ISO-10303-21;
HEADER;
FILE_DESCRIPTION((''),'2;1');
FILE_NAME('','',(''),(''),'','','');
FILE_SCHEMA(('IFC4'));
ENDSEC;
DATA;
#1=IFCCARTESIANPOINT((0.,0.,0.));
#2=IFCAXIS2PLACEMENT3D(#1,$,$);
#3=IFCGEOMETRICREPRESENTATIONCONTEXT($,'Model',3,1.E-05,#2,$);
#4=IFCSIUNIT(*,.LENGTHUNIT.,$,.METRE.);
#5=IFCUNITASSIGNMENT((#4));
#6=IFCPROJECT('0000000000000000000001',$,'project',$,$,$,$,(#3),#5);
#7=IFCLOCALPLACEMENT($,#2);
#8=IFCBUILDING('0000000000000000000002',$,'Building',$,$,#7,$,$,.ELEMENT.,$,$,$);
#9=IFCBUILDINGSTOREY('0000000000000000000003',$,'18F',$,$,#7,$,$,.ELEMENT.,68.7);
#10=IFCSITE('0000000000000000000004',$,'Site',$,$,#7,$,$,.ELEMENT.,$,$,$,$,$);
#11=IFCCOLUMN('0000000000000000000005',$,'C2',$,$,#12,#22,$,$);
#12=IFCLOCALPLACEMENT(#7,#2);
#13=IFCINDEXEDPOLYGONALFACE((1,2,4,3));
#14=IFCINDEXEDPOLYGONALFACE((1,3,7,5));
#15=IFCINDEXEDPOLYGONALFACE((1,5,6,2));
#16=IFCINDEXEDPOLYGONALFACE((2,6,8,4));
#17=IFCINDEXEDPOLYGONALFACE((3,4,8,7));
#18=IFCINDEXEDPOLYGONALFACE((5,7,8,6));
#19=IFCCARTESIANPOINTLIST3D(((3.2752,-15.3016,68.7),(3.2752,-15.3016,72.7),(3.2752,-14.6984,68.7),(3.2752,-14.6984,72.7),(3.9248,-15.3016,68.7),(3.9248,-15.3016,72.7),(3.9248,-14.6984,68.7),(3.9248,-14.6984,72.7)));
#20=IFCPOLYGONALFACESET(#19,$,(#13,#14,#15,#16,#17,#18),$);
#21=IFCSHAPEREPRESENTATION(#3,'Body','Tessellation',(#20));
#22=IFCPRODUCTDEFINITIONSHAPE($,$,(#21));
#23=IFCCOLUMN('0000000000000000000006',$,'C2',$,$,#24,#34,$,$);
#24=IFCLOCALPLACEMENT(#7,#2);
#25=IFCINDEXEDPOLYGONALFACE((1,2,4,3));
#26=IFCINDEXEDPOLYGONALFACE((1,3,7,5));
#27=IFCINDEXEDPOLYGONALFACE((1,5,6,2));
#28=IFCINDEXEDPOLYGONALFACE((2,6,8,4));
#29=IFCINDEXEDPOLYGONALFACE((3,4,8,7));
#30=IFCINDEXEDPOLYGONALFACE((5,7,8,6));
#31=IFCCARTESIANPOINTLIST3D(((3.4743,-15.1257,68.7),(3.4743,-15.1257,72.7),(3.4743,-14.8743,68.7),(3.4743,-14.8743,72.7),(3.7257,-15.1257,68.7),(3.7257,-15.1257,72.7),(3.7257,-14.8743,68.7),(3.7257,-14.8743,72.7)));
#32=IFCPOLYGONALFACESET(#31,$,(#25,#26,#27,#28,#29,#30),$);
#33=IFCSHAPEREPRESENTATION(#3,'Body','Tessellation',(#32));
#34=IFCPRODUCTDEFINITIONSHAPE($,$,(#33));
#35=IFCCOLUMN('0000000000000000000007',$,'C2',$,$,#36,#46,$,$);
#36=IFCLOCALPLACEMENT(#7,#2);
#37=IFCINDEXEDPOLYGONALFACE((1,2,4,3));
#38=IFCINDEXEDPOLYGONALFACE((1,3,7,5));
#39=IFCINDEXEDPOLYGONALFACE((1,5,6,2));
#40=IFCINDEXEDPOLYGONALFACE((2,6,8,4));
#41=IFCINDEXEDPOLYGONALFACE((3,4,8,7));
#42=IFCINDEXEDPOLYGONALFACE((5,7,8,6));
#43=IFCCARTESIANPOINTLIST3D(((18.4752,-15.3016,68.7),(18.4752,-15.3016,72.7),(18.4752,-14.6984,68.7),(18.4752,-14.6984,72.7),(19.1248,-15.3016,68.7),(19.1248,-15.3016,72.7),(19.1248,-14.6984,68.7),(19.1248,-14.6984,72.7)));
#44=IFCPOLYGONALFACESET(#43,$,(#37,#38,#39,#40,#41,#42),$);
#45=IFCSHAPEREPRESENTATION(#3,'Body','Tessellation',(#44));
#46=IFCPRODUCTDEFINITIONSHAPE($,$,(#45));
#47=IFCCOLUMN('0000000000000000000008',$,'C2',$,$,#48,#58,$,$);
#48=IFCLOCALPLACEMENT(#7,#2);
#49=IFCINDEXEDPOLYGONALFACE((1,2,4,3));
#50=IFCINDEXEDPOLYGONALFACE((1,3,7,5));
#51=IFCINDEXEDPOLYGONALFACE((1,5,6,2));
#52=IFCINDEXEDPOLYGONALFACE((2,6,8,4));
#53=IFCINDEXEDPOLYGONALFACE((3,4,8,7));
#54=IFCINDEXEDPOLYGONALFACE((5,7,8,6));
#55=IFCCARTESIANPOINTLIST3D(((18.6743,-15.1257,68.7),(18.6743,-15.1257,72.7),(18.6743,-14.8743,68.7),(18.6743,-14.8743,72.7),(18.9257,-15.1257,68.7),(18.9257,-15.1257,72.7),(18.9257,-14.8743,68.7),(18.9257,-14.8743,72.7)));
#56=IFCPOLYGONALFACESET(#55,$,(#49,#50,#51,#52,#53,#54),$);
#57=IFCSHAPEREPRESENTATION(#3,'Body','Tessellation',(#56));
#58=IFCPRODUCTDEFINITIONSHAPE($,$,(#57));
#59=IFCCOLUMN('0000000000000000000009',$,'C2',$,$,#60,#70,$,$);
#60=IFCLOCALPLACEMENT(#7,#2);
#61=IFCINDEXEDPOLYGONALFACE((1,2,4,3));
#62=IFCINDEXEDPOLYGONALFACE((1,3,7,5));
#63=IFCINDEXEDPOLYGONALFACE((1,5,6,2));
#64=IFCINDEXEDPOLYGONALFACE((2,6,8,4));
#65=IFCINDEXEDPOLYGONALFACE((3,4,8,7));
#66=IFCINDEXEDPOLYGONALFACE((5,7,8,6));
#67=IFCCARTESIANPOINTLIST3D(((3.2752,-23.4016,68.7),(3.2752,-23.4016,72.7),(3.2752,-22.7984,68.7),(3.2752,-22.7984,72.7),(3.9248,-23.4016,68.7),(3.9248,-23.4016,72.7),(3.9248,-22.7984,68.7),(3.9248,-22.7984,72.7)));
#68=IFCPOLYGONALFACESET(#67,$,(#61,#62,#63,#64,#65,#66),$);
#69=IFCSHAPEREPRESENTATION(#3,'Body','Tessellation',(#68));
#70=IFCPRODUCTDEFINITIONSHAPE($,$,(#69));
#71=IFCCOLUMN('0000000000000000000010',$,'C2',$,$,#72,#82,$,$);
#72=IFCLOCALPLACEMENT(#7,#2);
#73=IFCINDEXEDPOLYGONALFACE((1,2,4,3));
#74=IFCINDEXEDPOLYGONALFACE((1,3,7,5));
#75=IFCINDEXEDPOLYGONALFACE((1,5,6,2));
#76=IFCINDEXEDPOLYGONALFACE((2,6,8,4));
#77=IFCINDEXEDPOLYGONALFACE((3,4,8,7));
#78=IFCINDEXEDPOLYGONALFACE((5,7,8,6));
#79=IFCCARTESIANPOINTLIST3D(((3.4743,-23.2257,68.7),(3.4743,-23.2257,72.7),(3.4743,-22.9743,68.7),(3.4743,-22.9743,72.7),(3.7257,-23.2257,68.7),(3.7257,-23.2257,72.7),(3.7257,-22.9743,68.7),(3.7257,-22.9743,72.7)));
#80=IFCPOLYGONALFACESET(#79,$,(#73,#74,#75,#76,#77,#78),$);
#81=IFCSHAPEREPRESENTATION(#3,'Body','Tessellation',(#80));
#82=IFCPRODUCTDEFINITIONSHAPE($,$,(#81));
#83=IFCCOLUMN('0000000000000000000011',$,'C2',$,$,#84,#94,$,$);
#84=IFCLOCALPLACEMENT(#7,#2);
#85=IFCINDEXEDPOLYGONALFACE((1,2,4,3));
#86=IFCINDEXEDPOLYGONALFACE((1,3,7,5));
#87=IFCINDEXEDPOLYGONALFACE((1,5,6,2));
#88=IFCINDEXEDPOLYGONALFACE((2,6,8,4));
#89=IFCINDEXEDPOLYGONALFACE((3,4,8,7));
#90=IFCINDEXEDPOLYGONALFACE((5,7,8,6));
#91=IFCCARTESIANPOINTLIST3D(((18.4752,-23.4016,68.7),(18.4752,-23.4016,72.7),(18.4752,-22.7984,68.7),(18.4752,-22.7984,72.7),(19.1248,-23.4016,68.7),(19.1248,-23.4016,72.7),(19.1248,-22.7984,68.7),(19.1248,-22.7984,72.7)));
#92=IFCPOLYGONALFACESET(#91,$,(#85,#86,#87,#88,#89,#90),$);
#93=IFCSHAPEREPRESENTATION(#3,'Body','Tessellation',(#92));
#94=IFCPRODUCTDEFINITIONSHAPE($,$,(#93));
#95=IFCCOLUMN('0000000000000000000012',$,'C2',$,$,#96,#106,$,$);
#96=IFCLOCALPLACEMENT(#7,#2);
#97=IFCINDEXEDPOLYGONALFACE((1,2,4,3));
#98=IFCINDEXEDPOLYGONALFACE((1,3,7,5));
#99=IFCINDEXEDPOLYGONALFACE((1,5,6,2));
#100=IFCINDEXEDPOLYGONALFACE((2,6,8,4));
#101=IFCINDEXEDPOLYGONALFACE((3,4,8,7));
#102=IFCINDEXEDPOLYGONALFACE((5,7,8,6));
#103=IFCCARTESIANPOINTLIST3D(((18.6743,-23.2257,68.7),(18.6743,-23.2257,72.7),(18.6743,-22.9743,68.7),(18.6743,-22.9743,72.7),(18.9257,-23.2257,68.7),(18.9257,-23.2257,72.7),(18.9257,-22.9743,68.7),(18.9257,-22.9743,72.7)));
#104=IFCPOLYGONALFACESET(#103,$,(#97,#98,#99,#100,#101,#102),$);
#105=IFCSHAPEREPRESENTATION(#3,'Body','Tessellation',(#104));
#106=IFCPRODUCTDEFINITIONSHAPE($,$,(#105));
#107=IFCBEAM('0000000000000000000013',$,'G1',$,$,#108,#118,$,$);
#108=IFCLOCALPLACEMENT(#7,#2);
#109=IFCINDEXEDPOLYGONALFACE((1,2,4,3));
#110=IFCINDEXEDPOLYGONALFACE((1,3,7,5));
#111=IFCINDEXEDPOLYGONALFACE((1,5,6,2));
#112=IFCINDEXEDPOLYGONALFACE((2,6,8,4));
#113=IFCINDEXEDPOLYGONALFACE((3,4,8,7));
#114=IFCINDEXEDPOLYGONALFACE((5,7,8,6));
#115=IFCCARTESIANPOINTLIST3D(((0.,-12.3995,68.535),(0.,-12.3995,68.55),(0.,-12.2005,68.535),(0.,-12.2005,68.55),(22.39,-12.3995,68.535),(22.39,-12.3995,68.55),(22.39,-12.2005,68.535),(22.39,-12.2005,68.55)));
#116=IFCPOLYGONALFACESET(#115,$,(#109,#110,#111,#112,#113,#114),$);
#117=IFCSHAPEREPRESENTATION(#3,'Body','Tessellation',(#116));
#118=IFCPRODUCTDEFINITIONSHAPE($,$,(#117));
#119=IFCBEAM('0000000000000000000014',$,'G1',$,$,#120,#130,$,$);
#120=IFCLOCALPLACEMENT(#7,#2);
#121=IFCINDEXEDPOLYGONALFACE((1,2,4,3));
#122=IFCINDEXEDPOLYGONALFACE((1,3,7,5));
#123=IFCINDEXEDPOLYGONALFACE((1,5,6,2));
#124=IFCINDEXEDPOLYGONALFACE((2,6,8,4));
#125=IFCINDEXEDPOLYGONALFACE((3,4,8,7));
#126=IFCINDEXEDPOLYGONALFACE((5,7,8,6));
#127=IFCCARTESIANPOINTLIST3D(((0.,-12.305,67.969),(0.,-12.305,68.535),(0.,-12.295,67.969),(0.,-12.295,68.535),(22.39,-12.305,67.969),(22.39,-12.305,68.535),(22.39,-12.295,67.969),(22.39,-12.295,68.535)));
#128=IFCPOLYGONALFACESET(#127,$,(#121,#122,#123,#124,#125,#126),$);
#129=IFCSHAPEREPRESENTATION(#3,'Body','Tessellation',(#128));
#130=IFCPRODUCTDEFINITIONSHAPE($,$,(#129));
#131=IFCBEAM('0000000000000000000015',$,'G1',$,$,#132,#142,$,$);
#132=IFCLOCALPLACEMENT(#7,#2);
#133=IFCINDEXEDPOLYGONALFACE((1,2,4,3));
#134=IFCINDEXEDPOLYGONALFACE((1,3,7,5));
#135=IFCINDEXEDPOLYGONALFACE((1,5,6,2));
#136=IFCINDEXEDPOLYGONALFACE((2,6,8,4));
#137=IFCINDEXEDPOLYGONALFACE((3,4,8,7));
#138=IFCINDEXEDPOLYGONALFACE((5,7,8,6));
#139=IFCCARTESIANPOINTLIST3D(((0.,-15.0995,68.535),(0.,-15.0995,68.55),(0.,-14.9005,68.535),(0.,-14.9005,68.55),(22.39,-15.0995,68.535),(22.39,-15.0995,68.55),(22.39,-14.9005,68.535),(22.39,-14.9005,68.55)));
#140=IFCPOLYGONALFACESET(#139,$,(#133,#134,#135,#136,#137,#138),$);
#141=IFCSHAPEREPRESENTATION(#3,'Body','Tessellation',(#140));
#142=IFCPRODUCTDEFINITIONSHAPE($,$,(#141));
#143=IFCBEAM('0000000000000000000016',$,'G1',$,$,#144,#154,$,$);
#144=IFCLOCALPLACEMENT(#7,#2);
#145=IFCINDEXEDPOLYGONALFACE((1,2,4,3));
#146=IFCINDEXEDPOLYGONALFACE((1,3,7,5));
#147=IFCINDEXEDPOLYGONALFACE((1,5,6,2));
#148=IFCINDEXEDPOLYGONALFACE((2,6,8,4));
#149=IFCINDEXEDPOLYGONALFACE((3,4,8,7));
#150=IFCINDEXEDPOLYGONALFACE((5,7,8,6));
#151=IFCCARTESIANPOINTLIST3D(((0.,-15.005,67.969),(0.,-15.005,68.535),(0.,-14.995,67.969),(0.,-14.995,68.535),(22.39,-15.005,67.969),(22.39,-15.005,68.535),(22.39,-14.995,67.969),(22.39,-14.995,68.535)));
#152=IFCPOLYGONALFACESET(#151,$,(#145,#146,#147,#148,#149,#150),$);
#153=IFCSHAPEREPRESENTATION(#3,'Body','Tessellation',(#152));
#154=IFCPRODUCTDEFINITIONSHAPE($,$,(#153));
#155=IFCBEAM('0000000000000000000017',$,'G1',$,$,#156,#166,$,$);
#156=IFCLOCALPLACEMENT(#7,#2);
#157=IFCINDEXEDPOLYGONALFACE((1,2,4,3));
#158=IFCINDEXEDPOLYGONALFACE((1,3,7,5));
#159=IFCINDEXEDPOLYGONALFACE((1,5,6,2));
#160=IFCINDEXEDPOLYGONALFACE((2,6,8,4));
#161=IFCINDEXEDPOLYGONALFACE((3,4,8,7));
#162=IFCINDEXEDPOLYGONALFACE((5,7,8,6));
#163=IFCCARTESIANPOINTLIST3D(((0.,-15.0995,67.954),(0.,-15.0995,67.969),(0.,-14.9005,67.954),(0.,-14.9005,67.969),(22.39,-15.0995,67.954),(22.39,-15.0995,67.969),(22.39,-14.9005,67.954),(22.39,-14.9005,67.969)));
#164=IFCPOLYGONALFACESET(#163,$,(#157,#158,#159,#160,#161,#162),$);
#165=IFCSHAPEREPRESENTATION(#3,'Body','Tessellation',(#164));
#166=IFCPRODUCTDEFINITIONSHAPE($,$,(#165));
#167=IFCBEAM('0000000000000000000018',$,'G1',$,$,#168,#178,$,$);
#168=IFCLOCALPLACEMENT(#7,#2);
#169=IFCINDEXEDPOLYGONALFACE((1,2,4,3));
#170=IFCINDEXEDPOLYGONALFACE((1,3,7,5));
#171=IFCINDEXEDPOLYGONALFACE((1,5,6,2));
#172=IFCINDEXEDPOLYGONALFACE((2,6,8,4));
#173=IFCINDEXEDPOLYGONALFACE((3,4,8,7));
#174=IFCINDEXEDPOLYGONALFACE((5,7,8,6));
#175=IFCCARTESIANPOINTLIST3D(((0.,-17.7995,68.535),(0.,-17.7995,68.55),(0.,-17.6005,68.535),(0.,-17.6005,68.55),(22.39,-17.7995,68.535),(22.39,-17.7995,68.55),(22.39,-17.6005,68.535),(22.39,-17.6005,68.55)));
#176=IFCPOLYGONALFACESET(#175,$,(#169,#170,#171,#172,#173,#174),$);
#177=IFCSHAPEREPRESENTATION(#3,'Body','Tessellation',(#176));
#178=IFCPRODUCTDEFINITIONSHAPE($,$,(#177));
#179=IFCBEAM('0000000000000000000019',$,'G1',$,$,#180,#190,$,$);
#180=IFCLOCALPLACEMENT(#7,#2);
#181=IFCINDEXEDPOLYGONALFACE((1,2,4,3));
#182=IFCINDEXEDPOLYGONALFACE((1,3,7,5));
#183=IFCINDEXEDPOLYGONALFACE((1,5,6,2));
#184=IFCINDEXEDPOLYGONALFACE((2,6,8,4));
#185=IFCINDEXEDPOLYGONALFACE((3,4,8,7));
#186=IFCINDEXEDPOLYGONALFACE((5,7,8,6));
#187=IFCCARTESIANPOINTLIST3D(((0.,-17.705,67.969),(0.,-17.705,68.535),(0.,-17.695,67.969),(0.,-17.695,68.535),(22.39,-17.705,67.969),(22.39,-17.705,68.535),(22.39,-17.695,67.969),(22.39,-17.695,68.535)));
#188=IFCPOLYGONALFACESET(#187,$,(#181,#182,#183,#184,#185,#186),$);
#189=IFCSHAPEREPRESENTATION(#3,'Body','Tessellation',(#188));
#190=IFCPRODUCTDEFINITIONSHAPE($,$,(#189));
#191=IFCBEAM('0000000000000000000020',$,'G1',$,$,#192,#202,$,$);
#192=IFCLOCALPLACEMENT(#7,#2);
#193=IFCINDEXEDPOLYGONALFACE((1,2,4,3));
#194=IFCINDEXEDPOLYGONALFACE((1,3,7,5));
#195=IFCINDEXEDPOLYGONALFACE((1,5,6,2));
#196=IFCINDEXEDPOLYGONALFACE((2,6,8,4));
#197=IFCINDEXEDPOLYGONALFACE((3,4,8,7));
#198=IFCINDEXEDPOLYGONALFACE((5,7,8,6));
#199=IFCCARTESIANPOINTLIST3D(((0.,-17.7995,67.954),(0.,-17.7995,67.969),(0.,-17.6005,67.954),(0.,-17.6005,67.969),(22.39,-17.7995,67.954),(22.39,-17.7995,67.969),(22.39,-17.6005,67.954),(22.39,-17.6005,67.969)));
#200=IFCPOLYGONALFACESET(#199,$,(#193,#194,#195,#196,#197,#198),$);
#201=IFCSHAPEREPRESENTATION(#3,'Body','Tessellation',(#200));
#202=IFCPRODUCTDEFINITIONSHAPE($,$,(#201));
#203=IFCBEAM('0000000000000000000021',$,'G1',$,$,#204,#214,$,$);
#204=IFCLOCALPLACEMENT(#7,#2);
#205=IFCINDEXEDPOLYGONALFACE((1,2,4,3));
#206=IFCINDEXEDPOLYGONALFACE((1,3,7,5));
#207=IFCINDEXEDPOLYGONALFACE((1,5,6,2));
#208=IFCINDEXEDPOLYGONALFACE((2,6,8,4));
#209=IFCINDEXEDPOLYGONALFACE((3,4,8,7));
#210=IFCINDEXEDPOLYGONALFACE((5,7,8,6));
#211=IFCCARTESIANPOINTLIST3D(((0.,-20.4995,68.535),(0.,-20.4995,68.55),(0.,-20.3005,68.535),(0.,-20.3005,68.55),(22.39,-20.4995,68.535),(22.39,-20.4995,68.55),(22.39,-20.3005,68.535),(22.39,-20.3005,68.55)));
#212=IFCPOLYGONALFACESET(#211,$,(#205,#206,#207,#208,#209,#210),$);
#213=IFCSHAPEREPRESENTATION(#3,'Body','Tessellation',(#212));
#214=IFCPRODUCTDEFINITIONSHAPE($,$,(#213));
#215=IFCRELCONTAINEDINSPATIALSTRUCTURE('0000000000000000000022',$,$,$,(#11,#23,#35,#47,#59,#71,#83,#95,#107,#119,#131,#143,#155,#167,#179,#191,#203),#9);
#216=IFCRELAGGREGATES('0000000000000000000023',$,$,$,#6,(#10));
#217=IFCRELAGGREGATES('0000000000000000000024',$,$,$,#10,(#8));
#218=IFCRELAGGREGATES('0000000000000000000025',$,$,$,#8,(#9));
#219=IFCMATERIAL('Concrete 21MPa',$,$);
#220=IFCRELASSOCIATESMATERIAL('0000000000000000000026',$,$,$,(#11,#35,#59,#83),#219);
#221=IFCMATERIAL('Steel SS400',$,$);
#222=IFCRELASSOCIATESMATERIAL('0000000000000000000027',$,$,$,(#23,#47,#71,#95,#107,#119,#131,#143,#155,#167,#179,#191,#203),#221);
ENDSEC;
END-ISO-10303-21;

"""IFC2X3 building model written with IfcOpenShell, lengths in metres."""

from ifc_helpers import new_model, si_unit, frame, origin, origin_2d, place, context, project, spatial, rectangle, extrude, material, element, save


model = new_model("IFC2X3")

# Units and contexts
model_context = context("Model", 3, precision=1e-05, world=origin())
ifc_project = project(units=[si_unit("LENGTHUNIT", "METRE")], contexts=[model_context])

# Site, building, storey
placement = place(None, origin())
site = spatial("IfcSite", under=ifc_project, at=placement, Name="Site", CompositionType="ELEMENT")
building = spatial("IfcBuilding", under=site, at=placement, Name="Building", CompositionType="ELEMENT")
storey = spatial("IfcBuildingStorey", under=building, at=placement, Name="18F", CompositionType="ELEMENT", Elevation=68.7)

# Columns
ifc_material_1 = material(Name="Concrete 21MPa")
column_1_placement = place(None, frame((3.6, -15.0, 68.7)))
element("IfcColumn", 1, at=column_1_placement, inside=storey, material=ifc_material_1, Name="C2", context=model_context, shape_type="SweptSolid", body=[
    extrude(rectangle(XDim=0.6496, YDim=0.6032, at=origin_2d()), origin(), (0.0, 0.0, 1.0), 4.0),
])
ifc_material_2 = material(Name="Steel SS400")
column_2_placement = place(None, frame((3.6, -15.0, 68.7)))
element("IfcColumn", 2, at=column_2_placement, inside=storey, material=ifc_material_2, Name="C2", context=model_context, shape_type="SweptSolid", body=[
    extrude(rectangle(XDim=0.2513, YDim=0.2513, at=origin_2d()), origin(), (0.0, 0.0, 1.0), 4.0),
])
column_3_placement = place(None, frame((18.8, -15.0, 68.7)))
element("IfcColumn", 3, at=column_3_placement, inside=storey, material=ifc_material_1, Name="C2", context=model_context, shape_type="SweptSolid", body=[
    extrude(rectangle(XDim=0.6496, YDim=0.6032, at=origin_2d()), origin(), (0.0, 0.0, 1.0), 4.0),
])
column_4_placement = place(None, frame((18.8, -15.0, 68.7)))
element("IfcColumn", 4, at=column_4_placement, inside=storey, material=ifc_material_2, Name="C2", context=model_context, shape_type="SweptSolid", body=[
    extrude(rectangle(XDim=0.2513, YDim=0.2513, at=origin_2d()), origin(), (0.0, 0.0, 1.0), 4.0),
])
column_5_placement = place(None, frame((3.6, -23.1, 68.7)))
element("IfcColumn", 5, at=column_5_placement, inside=storey, material=ifc_material_1, Name="C2", context=model_context, shape_type="SweptSolid", body=[
    extrude(rectangle(XDim=0.6496, YDim=0.6032, at=origin_2d()), origin(), (0.0, 0.0, 1.0), 4.0),
])
column_6_placement = place(None, frame((3.6, -23.1, 68.7)))
element("IfcColumn", 6, at=column_6_placement, inside=storey, material=ifc_material_2, Name="C2", context=model_context, shape_type="SweptSolid", body=[
    extrude(rectangle(XDim=0.2513, YDim=0.2513, at=origin_2d()), origin(), (0.0, 0.0, 1.0), 4.0),
])
column_7_placement = place(None, frame((18.8, -23.1, 68.7)))
element("IfcColumn", 7, at=column_7_placement, inside=storey, material=ifc_material_1, Name="C2", context=model_context, shape_type="SweptSolid", body=[
    extrude(rectangle(XDim=0.6496, YDim=0.6032, at=origin_2d()), origin(), (0.0, 0.0, 1.0), 4.0),
])
column_8_placement = place(None, frame((18.8, -23.1, 68.7)))
element("IfcColumn", 8, at=column_8_placement, inside=storey, material=ifc_material_2, Name="C2", context=model_context, shape_type="SweptSolid", body=[
    extrude(rectangle(XDim=0.2513, YDim=0.2513, at=origin_2d()), origin(), (0.0, 0.0, 1.0), 4.0),
])

# Beams
beam_1_placement = place(None, frame((11.195, -12.3, 68.535)))
element("IfcBeam", 9, at=beam_1_placement, inside=storey, material=ifc_material_2, Name="G1", context=model_context, shape_type="SweptSolid", body=[
    extrude(rectangle(XDim=22.39, YDim=0.199, at=origin_2d()), origin(), (0.0, 0.0, 1.0), 0.015),
])
beam_2_placement = place(None, frame((11.195, -12.3, 67.969)))
element("IfcBeam", 10, at=beam_2_placement, inside=storey, material=ifc_material_2, Name="G1", context=model_context, shape_type="SweptSolid", body=[
    extrude(rectangle(XDim=22.39, YDim=0.01, at=origin_2d()), origin(), (0.0, 0.0, 1.0), 0.566),
])
beam_3_placement = place(None, frame((11.195, -15.0, 68.535)))
element("IfcBeam", 11, at=beam_3_placement, inside=storey, material=ifc_material_2, Name="G1", context=model_context, shape_type="SweptSolid", body=[
    extrude(rectangle(XDim=22.39, YDim=0.199, at=origin_2d()), origin(), (0.0, 0.0, 1.0), 0.015),
])
beam_4_placement = place(None, frame((11.195, -15.0, 67.969)))
element("IfcBeam", 12, at=beam_4_placement, inside=storey, material=ifc_material_2, Name="G1", context=model_context, shape_type="SweptSolid", body=[
    extrude(rectangle(XDim=22.39, YDim=0.01, at=origin_2d()), origin(), (0.0, 0.0, 1.0), 0.566),
])
for number, where, name in (
    (13, (11.195, -15.0, 67.954), "G1"),
    (14, (11.195, -17.7, 68.535), "G1"),
):
    element("IfcBeam", number, at=place(None, frame(where)), inside=storey, material=ifc_material_2, Name=name, context=model_context, shape_type="SweptSolid", body=[
        extrude(rectangle(XDim=22.39, YDim=0.199, at=origin_2d()), origin(), (0.0, 0.0, 1.0), 0.015),
    ])
beam_5_placement = place(None, frame((11.195, -17.7, 67.969)))
element("IfcBeam", 15, at=beam_5_placement, inside=storey, material=ifc_material_2, Name="G1", context=model_context, shape_type="SweptSolid", body=[
    extrude(rectangle(XDim=22.39, YDim=0.01, at=origin_2d()), origin(), (0.0, 0.0, 1.0), 0.566),
])
for number, where, name in (
    (16, (11.195, -17.7, 67.954), "G1"),
    (17, (11.195, -20.4, 68.535), "G1"),
):
    element("IfcBeam", number, at=place(None, frame(where)), inside=storey, material=ifc_material_2, Name=name, context=model_context, shape_type="SweptSolid", body=[
        extrude(rectangle(XDim=22.39, YDim=0.199, at=origin_2d()), origin(), (0.0, 0.0, 1.0), 0.015),
    ])

save(model, "model.ifc")
